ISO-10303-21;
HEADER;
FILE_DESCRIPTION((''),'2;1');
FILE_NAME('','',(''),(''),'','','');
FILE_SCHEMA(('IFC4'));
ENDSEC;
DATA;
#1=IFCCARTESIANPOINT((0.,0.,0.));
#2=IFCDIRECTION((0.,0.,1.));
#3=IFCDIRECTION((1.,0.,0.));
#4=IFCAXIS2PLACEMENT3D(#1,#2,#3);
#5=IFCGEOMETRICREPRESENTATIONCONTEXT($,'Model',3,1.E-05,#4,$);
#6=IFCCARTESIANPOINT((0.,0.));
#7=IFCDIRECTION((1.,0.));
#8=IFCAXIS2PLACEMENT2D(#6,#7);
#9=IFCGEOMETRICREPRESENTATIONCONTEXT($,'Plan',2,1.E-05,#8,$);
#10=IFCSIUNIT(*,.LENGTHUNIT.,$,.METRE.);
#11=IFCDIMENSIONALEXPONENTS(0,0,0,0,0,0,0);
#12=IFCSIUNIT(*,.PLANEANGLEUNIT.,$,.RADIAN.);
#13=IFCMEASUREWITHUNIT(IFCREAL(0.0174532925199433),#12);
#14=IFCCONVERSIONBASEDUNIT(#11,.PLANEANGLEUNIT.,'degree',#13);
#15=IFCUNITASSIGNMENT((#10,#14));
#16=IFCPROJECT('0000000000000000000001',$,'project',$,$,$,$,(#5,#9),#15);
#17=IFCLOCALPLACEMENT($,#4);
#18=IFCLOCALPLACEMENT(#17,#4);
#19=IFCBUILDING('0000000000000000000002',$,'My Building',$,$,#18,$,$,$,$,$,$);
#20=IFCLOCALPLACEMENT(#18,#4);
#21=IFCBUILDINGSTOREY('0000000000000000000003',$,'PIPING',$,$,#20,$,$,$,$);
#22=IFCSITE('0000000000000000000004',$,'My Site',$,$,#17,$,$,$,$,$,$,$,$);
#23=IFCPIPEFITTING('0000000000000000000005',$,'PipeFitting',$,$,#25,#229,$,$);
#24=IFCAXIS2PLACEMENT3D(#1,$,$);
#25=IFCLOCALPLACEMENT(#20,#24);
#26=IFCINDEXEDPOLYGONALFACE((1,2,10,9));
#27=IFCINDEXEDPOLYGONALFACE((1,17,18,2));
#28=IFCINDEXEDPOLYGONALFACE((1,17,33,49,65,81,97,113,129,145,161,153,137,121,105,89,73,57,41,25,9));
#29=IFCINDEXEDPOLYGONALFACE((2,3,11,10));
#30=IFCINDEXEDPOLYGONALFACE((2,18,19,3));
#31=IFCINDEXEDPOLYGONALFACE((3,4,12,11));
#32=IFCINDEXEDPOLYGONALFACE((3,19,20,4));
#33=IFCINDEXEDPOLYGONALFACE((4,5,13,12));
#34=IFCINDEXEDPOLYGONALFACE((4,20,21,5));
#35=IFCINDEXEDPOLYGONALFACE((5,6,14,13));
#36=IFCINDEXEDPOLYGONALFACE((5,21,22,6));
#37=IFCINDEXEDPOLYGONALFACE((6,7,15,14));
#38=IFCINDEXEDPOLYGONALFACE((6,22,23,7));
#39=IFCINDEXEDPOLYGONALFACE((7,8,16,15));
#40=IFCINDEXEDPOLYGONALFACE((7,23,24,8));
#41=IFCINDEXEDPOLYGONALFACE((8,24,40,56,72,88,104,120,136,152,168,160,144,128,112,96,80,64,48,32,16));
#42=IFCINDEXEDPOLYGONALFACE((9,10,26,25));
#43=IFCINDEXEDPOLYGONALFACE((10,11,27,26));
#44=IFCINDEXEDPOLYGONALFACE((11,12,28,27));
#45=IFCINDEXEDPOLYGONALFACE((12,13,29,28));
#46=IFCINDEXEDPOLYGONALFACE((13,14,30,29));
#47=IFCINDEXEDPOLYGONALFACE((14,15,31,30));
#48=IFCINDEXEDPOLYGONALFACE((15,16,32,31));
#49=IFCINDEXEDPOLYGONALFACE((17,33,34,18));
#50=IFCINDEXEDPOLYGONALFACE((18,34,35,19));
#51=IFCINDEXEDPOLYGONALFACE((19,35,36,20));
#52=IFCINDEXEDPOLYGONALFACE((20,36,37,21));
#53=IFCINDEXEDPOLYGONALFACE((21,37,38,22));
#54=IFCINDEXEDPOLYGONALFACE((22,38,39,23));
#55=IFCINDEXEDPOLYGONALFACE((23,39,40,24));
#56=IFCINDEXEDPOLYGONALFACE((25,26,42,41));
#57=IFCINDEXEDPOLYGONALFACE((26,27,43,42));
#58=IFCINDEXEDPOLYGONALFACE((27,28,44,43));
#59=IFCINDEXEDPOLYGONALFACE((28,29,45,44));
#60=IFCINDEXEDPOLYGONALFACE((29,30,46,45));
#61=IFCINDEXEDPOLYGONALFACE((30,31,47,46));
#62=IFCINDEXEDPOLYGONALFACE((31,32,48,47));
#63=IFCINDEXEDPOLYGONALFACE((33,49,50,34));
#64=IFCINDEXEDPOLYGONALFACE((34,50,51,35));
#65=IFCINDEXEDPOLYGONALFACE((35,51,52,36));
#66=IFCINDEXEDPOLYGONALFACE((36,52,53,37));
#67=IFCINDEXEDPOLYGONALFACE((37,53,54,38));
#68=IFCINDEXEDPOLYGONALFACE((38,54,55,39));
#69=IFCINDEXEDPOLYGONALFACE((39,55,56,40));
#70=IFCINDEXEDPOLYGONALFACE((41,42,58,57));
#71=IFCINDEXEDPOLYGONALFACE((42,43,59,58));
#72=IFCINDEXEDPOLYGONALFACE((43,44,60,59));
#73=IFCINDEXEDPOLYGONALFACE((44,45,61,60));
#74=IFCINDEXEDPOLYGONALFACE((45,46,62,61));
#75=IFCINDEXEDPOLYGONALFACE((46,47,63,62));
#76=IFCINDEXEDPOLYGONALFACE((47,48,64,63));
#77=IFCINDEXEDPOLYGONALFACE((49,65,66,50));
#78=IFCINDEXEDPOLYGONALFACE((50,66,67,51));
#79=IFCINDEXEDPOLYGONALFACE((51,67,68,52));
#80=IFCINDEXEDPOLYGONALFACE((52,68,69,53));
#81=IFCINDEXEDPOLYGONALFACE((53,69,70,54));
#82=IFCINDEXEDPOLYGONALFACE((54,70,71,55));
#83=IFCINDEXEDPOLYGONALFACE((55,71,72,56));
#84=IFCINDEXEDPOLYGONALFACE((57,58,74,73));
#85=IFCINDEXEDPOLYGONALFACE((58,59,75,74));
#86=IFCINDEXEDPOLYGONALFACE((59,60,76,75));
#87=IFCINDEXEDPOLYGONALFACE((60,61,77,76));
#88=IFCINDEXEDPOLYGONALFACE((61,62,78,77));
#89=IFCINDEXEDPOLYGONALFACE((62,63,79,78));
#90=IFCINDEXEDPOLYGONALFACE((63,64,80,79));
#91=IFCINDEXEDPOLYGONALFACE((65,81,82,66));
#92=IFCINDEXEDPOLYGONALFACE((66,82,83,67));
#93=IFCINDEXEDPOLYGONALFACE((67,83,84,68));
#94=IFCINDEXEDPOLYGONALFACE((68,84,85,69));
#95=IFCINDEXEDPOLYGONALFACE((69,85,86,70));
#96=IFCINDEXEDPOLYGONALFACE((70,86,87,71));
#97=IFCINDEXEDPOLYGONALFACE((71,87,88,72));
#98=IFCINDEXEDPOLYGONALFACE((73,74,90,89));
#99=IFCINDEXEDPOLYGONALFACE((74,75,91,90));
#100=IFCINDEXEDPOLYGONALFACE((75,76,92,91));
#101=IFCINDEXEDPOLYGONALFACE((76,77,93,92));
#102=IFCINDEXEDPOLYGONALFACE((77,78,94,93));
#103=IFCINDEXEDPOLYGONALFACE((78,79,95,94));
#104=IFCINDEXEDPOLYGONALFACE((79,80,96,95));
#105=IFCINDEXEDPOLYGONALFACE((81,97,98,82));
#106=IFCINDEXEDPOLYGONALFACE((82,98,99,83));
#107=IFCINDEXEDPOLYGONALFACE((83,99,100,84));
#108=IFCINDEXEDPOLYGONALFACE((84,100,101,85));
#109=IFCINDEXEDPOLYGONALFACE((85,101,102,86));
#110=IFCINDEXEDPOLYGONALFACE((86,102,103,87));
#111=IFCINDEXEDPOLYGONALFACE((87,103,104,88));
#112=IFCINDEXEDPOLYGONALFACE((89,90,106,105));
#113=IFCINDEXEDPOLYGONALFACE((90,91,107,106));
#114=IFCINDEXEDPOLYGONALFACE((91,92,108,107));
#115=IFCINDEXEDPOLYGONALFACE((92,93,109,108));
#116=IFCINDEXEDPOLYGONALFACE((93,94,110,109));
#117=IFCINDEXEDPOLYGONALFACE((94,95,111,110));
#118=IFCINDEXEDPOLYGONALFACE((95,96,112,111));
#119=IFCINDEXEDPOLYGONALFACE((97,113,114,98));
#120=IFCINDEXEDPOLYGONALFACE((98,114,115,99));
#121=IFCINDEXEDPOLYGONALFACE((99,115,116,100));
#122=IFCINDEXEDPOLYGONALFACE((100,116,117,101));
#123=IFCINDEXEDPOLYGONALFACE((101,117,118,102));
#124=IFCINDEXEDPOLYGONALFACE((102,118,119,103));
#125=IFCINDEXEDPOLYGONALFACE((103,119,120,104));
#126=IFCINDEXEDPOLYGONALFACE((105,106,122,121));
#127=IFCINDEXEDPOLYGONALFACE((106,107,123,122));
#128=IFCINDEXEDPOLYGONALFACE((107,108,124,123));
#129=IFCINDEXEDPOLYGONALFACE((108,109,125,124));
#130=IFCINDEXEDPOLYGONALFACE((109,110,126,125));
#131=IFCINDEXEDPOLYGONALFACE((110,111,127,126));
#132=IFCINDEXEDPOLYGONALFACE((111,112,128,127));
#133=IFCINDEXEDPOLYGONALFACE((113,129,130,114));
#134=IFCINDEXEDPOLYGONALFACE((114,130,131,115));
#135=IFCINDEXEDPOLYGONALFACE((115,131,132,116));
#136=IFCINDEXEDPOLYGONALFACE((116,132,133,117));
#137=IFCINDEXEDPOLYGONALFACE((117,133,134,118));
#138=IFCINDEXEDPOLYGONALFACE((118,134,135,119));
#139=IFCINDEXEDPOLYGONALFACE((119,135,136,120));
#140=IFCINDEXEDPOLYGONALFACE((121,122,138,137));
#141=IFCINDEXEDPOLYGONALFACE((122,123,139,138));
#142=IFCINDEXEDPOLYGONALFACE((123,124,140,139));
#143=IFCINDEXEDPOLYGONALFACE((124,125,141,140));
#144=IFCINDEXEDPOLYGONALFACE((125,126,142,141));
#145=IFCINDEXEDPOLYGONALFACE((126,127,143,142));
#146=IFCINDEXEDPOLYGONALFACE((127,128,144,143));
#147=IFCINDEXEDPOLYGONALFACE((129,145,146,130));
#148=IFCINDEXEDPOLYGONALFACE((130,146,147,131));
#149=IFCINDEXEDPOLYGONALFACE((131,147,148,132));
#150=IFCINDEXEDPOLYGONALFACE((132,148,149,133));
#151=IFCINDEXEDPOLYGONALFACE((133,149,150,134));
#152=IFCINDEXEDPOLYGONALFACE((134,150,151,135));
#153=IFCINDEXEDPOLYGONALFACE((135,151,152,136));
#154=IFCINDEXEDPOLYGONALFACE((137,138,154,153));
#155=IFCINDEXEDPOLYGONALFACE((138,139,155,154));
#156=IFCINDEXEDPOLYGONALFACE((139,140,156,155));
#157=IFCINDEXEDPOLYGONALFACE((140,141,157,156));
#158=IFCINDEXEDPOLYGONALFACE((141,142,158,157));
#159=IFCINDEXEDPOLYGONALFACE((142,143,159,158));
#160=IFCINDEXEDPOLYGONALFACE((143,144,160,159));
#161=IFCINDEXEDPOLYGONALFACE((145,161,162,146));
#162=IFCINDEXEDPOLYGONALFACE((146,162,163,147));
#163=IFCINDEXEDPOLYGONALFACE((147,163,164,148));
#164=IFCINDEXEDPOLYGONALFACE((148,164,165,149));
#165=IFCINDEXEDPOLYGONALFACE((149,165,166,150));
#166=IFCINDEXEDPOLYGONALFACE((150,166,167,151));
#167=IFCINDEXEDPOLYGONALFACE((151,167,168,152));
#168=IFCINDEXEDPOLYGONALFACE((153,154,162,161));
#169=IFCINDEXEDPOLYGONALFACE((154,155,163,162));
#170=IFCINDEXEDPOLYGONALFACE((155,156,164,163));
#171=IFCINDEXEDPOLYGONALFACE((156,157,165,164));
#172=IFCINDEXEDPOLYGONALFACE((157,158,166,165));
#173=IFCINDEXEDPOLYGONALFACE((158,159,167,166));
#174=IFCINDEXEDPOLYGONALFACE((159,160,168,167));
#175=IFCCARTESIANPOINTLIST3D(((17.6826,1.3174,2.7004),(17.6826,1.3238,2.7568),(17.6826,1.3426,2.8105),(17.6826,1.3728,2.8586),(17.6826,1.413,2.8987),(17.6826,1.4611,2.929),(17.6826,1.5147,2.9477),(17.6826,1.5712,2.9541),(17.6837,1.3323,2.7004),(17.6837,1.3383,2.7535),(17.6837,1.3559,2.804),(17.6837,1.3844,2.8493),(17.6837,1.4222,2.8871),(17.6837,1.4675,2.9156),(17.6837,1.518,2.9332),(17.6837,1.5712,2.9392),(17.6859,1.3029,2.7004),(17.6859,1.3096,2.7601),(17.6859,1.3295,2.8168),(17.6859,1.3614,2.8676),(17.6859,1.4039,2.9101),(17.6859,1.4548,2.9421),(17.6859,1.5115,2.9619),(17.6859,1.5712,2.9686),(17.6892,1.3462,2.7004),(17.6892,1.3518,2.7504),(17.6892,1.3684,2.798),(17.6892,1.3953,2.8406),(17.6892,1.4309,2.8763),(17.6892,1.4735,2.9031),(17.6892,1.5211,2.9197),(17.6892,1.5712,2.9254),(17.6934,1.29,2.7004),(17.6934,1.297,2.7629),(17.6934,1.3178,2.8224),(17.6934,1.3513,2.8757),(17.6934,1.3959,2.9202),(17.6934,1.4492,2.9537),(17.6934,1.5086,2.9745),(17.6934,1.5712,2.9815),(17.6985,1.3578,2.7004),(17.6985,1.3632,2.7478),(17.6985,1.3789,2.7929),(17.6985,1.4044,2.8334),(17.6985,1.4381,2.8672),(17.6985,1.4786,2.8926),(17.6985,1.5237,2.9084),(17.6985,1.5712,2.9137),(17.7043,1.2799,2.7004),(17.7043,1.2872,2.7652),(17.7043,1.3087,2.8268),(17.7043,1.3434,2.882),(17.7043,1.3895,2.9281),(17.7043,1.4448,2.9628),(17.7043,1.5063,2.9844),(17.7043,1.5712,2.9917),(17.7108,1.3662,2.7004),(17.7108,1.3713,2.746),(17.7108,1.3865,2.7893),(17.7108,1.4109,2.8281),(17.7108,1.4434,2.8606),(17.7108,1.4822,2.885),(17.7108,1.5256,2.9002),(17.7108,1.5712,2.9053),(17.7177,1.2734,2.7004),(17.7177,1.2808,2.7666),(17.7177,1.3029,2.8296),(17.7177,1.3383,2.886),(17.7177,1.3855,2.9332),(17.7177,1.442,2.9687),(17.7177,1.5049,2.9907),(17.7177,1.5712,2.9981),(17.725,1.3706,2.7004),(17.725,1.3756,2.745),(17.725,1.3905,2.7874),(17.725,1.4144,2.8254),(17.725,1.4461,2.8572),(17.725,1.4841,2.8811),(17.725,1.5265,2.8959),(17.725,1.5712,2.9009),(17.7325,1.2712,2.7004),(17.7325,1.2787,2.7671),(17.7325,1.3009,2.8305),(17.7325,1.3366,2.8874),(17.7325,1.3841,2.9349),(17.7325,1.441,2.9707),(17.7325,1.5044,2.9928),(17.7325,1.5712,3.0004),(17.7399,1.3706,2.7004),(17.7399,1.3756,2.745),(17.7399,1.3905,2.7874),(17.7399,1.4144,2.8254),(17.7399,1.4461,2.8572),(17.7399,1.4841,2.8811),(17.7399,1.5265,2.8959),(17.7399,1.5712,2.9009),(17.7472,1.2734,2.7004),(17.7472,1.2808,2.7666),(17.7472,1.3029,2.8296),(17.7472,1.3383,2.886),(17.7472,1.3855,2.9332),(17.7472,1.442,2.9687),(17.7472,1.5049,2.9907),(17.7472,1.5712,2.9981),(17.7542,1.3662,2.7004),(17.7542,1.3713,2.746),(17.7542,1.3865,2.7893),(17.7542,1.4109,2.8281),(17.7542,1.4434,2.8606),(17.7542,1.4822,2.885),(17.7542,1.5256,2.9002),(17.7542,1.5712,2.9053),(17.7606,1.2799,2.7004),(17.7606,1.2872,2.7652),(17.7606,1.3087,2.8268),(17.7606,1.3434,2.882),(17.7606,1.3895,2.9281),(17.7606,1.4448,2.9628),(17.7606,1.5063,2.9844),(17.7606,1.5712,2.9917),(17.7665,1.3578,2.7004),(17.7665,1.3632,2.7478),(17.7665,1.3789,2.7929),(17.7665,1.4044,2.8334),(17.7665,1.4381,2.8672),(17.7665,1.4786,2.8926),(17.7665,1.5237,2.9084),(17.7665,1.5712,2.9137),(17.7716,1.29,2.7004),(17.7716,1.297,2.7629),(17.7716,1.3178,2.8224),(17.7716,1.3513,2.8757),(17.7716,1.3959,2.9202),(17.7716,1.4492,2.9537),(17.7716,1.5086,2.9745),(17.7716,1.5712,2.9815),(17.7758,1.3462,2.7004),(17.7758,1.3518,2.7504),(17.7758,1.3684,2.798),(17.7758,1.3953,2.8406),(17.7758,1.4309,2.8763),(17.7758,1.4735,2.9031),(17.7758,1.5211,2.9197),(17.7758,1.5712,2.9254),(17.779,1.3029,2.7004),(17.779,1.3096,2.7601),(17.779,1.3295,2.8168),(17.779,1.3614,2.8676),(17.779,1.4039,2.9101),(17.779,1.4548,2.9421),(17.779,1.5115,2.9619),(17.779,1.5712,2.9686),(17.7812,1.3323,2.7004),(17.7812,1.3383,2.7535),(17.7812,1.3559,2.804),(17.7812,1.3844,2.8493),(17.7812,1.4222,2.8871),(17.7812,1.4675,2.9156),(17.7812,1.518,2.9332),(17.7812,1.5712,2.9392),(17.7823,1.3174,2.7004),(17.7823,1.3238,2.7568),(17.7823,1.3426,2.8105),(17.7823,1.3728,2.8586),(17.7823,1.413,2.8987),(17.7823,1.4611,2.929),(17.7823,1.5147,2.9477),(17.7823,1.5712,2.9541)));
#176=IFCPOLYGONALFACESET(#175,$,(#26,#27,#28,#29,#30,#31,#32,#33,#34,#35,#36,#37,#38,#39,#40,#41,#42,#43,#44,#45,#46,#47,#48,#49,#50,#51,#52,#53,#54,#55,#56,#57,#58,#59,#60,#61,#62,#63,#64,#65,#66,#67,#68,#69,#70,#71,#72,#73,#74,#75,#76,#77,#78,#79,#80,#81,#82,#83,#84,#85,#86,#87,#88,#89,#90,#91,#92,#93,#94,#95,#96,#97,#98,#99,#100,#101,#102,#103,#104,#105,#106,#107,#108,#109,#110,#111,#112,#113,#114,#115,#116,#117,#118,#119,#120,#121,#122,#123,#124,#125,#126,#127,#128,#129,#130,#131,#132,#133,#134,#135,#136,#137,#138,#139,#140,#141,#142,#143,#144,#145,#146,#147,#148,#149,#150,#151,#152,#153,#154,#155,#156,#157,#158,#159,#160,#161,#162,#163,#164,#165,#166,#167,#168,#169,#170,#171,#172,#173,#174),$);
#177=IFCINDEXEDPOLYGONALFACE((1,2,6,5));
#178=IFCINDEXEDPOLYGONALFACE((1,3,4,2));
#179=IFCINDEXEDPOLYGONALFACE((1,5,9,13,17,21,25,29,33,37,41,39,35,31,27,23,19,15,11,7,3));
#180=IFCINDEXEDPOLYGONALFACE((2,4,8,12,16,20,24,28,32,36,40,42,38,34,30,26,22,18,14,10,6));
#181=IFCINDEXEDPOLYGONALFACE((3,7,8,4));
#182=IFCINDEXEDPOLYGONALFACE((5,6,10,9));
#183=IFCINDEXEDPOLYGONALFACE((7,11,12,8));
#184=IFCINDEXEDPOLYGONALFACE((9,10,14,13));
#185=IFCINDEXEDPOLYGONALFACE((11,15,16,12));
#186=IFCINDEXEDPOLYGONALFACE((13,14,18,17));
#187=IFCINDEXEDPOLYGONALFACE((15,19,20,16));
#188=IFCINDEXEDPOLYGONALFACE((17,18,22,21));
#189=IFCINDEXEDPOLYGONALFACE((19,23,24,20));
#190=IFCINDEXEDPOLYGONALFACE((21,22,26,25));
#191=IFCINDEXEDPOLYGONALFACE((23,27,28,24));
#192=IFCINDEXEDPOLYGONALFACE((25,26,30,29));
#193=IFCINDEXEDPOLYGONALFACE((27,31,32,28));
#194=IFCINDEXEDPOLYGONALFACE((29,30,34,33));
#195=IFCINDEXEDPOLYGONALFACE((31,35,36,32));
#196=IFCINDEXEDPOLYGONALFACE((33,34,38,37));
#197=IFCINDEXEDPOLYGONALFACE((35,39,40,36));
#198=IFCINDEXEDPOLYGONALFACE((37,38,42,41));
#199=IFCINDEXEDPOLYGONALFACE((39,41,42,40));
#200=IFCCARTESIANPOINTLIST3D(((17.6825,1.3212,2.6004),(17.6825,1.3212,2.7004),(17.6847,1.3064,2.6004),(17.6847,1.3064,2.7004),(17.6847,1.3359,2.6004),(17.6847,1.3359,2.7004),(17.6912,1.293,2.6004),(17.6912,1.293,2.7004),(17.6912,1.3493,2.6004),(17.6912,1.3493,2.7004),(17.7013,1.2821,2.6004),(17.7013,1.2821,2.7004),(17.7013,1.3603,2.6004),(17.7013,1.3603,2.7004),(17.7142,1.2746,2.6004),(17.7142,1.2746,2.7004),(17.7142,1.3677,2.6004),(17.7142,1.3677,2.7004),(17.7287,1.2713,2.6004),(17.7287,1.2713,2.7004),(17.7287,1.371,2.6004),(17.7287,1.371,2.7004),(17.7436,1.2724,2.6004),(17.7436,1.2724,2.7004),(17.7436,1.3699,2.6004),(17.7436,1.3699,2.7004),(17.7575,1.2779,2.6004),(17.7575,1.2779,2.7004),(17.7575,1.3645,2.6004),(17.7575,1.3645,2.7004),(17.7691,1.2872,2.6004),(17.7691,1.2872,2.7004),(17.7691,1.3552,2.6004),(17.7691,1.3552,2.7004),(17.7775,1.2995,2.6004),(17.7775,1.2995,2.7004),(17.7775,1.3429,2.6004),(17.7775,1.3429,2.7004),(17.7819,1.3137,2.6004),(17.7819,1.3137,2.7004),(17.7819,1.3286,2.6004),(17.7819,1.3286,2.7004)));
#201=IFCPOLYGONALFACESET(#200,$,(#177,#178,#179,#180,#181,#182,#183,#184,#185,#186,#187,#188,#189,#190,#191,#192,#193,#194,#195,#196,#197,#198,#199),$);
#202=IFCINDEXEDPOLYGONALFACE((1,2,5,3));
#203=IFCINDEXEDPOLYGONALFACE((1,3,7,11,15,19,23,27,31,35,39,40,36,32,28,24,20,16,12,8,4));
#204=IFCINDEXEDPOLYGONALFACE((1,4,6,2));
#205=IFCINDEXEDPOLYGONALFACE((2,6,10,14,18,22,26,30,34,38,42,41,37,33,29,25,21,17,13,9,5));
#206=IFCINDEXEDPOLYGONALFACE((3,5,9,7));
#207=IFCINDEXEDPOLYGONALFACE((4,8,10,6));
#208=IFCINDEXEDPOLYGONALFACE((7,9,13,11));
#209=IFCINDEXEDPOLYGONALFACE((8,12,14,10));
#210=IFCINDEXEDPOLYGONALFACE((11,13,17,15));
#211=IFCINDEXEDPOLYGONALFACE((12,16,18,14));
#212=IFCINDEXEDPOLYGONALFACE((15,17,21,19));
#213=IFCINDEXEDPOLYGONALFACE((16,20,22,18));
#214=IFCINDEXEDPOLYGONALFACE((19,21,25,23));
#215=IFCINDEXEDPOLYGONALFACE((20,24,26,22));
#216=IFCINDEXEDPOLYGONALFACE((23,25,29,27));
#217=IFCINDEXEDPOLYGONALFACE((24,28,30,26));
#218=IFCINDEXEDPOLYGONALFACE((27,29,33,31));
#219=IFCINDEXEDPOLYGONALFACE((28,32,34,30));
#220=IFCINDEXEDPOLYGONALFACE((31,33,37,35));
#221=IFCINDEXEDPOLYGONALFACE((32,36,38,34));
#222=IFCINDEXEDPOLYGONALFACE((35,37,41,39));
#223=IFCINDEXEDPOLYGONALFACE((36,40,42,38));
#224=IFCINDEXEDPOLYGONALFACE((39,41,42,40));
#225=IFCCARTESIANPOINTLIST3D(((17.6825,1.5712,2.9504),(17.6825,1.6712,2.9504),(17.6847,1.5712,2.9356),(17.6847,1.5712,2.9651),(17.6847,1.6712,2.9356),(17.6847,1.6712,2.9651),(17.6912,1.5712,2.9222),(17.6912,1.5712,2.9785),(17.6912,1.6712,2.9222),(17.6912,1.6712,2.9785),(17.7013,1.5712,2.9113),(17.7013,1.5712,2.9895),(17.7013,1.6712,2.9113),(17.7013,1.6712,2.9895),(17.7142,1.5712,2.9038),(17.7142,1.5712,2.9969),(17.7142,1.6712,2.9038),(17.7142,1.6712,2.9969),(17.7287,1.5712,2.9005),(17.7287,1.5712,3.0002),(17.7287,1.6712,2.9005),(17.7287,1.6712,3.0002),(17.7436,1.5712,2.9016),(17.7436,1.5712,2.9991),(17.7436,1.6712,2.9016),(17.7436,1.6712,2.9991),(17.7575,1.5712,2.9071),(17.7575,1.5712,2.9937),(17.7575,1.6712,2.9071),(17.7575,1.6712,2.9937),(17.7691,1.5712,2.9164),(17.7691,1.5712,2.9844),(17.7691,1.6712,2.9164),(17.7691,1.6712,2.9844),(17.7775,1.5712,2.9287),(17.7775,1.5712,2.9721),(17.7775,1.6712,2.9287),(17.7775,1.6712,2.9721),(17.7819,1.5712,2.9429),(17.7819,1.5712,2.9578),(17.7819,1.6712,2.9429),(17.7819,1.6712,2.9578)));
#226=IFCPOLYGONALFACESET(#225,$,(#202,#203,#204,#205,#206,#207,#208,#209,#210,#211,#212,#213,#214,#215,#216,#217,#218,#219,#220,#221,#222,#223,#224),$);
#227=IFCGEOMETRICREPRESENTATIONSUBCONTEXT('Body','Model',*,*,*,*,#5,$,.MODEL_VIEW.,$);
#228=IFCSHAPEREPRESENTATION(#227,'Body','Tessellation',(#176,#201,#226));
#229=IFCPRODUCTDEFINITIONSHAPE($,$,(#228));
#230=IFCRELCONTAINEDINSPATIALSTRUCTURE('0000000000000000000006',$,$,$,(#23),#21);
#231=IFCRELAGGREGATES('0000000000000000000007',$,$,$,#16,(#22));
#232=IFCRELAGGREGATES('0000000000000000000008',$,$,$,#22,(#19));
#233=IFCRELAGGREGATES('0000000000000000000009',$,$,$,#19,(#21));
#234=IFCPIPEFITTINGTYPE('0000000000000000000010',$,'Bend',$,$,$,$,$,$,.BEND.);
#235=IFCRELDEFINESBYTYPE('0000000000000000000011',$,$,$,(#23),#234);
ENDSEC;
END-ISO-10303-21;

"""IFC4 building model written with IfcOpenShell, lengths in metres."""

from ifc_helpers import new_model, entity, si_unit, converted_unit, frame, origin_with_axes, origin_2d_with_axis, place, context, subcontext, project, spatial, circle, extrude, source, transform, mapped, type_object, type_shapes, element, save


model = new_model("IFC4")

# Units and contexts
model_context = context("Model", 3, precision=1e-05, world=origin_with_axes())
plan_context = context("Plan", 2, precision=1e-05, world=origin_2d_with_axis())
body_context = subcontext(model_context, "Body", "Model", "MODEL_VIEW")
ifc_project = project(units=[si_unit("LENGTHUNIT", "METRE"), converted_unit("PLANEANGLEUNIT", "degree", entity("IfcReal", 0.0174532925199433), si_unit("PLANEANGLEUNIT", "RADIAN"), dimensions=[0, 0, 0, 0, 0, 0, 0])], contexts=[model_context, plan_context])

# Site, building, storey
site_placement = place(None, origin_with_axes())
site = spatial("IfcSite", under=ifc_project, at=site_placement, Name="My Site")
building_placement = place(site_placement, origin_with_axes())
building = spatial("IfcBuilding", under=site, at=building_placement, Name="My Building")
storey_placement = place(building_placement, origin_with_axes())
storey = spatial("IfcBuildingStorey", under=building, at=storey_placement, Name="PIPING")

# Pipe fitting
pipe_fitting_type_1 = type_object("IfcPipeFittingType", Name="Bend", PredefinedType="BEND")
shared_shape = source(origin_with_axes(), body_context, "Body", "SolidModel", [
    entity("IfcSweptDiskSolid", entity("IfcIndexedPolyCurve", entity("IfcCartesianPointList3D", [[0.0, 0.0, -0.1], [0.0, 0.0732, -0.2768], [0.0, 0.25, -0.35]]), [entity("IfcArcIndex", [1, 2, 3])]), 0.05),
    extrude(circle(Radius=0.05), origin_with_axes(), (0.0, 0.0, -1.0), 0.1),
    extrude(circle(Radius=0.05), frame((0.0, 0.25, -0.35), z_axis=(0.0, 1.0, 0.0), x_axis=(1.0, 0.0, 0.0)), (0.0, 0.0, 1.0), 0.1),
])
type_shapes(pipe_fitting_type_1, [shared_shape])
for number, where, z_axis, x_axis, name in (
    (1, (17.7325, 1.3212, 2.6004), (0.0, 0.0, -1.0), (-1.0, 0.0, 0.0), "PipeFitting"),
):
    element("IfcPipeFitting", number, at=place(storey_placement, frame(where, z_axis=z_axis, x_axis=x_axis)), inside=storey, type_object=pipe_fitting_type_1, Name=name, context=body_context, shape_type="MappedRepresentation", body=[
        mapped(shared_shape, transform((0.0, 0.0, 0.0), x_axis=(1.0, 0.0, 0.0), y_axis=(0.0, 1.0, 0.0), z_axis=(0.0, 0.0, 1.0), scale=1.0)),
    ])

save(model, "model.ifc")
